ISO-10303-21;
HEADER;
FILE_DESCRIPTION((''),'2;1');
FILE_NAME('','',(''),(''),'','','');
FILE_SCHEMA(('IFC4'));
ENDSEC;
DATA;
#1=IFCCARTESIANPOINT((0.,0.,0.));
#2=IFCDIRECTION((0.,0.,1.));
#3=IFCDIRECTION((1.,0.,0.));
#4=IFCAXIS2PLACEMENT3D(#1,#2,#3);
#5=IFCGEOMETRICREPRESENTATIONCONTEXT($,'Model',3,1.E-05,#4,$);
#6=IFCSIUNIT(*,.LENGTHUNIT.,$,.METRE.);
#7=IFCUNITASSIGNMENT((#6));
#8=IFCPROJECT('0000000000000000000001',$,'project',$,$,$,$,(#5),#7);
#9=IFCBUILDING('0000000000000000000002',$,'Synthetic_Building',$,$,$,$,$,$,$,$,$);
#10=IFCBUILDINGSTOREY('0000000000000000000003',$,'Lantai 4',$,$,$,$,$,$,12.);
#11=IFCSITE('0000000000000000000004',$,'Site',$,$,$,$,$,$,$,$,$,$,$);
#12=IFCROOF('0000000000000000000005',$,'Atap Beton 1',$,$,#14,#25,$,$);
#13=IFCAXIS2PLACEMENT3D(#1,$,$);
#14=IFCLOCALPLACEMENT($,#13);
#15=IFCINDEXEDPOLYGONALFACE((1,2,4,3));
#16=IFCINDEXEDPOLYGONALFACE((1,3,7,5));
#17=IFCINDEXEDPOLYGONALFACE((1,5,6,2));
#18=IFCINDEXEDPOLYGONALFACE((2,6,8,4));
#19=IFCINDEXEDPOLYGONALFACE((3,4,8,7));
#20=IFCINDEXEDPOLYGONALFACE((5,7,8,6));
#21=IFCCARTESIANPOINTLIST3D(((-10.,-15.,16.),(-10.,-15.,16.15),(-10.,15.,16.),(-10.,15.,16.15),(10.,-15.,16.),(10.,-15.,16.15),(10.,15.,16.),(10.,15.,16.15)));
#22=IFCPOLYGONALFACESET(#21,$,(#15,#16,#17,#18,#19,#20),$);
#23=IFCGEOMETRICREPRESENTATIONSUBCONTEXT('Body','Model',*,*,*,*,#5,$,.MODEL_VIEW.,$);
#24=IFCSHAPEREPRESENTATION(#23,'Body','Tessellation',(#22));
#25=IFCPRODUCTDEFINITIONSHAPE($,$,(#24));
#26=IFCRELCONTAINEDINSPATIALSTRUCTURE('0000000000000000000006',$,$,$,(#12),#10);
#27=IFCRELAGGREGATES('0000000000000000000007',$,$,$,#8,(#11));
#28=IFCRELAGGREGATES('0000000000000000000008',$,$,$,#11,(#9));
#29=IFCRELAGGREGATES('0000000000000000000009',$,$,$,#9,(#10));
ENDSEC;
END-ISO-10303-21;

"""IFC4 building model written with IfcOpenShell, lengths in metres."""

from ifc_helpers import new_model, si_unit, frame, origin_with_axes, place, context, subcontext, project, spatial, polyline, outline, extrude, element, save


model = new_model("IFC4")

# Units and contexts
model_context = context("Model", 3, precision=1e-05, world=origin_with_axes())
body_context = subcontext(model_context, "Body", "Model", "MODEL_VIEW")
ifc_project = project(units=[si_unit("LENGTHUNIT", "METRE")], contexts=[model_context])

# Site, building, storey
site = spatial("IfcSite", under=ifc_project, Name="Site")
building = spatial("IfcBuilding", under=site, Name="Synthetic_Building")
storey = spatial("IfcBuildingStorey", under=building, Name="Lantai 4", Elevation=12.0)

# Roof
roof_placement = place(None, origin_with_axes())
element("IfcRoof", 1, at=roof_placement, inside=storey, Name="Atap Beton 1", context=body_context, shape_type="SweptSolid", body=[
    extrude(outline(polyline([(-10.0, -15.0), (10.0, -15.0), (10.0, 15.0), (-10.0, 15.0), (-10.0, -15.0)])), frame((0.0, 0.0, 16.0), z_axis=(0.0, 0.0, 1.0), x_axis=(1.0, 0.0, 0.0)), (0.0, 0.0, 1.0), 0.15),
])

save(model, "model.ifc")
